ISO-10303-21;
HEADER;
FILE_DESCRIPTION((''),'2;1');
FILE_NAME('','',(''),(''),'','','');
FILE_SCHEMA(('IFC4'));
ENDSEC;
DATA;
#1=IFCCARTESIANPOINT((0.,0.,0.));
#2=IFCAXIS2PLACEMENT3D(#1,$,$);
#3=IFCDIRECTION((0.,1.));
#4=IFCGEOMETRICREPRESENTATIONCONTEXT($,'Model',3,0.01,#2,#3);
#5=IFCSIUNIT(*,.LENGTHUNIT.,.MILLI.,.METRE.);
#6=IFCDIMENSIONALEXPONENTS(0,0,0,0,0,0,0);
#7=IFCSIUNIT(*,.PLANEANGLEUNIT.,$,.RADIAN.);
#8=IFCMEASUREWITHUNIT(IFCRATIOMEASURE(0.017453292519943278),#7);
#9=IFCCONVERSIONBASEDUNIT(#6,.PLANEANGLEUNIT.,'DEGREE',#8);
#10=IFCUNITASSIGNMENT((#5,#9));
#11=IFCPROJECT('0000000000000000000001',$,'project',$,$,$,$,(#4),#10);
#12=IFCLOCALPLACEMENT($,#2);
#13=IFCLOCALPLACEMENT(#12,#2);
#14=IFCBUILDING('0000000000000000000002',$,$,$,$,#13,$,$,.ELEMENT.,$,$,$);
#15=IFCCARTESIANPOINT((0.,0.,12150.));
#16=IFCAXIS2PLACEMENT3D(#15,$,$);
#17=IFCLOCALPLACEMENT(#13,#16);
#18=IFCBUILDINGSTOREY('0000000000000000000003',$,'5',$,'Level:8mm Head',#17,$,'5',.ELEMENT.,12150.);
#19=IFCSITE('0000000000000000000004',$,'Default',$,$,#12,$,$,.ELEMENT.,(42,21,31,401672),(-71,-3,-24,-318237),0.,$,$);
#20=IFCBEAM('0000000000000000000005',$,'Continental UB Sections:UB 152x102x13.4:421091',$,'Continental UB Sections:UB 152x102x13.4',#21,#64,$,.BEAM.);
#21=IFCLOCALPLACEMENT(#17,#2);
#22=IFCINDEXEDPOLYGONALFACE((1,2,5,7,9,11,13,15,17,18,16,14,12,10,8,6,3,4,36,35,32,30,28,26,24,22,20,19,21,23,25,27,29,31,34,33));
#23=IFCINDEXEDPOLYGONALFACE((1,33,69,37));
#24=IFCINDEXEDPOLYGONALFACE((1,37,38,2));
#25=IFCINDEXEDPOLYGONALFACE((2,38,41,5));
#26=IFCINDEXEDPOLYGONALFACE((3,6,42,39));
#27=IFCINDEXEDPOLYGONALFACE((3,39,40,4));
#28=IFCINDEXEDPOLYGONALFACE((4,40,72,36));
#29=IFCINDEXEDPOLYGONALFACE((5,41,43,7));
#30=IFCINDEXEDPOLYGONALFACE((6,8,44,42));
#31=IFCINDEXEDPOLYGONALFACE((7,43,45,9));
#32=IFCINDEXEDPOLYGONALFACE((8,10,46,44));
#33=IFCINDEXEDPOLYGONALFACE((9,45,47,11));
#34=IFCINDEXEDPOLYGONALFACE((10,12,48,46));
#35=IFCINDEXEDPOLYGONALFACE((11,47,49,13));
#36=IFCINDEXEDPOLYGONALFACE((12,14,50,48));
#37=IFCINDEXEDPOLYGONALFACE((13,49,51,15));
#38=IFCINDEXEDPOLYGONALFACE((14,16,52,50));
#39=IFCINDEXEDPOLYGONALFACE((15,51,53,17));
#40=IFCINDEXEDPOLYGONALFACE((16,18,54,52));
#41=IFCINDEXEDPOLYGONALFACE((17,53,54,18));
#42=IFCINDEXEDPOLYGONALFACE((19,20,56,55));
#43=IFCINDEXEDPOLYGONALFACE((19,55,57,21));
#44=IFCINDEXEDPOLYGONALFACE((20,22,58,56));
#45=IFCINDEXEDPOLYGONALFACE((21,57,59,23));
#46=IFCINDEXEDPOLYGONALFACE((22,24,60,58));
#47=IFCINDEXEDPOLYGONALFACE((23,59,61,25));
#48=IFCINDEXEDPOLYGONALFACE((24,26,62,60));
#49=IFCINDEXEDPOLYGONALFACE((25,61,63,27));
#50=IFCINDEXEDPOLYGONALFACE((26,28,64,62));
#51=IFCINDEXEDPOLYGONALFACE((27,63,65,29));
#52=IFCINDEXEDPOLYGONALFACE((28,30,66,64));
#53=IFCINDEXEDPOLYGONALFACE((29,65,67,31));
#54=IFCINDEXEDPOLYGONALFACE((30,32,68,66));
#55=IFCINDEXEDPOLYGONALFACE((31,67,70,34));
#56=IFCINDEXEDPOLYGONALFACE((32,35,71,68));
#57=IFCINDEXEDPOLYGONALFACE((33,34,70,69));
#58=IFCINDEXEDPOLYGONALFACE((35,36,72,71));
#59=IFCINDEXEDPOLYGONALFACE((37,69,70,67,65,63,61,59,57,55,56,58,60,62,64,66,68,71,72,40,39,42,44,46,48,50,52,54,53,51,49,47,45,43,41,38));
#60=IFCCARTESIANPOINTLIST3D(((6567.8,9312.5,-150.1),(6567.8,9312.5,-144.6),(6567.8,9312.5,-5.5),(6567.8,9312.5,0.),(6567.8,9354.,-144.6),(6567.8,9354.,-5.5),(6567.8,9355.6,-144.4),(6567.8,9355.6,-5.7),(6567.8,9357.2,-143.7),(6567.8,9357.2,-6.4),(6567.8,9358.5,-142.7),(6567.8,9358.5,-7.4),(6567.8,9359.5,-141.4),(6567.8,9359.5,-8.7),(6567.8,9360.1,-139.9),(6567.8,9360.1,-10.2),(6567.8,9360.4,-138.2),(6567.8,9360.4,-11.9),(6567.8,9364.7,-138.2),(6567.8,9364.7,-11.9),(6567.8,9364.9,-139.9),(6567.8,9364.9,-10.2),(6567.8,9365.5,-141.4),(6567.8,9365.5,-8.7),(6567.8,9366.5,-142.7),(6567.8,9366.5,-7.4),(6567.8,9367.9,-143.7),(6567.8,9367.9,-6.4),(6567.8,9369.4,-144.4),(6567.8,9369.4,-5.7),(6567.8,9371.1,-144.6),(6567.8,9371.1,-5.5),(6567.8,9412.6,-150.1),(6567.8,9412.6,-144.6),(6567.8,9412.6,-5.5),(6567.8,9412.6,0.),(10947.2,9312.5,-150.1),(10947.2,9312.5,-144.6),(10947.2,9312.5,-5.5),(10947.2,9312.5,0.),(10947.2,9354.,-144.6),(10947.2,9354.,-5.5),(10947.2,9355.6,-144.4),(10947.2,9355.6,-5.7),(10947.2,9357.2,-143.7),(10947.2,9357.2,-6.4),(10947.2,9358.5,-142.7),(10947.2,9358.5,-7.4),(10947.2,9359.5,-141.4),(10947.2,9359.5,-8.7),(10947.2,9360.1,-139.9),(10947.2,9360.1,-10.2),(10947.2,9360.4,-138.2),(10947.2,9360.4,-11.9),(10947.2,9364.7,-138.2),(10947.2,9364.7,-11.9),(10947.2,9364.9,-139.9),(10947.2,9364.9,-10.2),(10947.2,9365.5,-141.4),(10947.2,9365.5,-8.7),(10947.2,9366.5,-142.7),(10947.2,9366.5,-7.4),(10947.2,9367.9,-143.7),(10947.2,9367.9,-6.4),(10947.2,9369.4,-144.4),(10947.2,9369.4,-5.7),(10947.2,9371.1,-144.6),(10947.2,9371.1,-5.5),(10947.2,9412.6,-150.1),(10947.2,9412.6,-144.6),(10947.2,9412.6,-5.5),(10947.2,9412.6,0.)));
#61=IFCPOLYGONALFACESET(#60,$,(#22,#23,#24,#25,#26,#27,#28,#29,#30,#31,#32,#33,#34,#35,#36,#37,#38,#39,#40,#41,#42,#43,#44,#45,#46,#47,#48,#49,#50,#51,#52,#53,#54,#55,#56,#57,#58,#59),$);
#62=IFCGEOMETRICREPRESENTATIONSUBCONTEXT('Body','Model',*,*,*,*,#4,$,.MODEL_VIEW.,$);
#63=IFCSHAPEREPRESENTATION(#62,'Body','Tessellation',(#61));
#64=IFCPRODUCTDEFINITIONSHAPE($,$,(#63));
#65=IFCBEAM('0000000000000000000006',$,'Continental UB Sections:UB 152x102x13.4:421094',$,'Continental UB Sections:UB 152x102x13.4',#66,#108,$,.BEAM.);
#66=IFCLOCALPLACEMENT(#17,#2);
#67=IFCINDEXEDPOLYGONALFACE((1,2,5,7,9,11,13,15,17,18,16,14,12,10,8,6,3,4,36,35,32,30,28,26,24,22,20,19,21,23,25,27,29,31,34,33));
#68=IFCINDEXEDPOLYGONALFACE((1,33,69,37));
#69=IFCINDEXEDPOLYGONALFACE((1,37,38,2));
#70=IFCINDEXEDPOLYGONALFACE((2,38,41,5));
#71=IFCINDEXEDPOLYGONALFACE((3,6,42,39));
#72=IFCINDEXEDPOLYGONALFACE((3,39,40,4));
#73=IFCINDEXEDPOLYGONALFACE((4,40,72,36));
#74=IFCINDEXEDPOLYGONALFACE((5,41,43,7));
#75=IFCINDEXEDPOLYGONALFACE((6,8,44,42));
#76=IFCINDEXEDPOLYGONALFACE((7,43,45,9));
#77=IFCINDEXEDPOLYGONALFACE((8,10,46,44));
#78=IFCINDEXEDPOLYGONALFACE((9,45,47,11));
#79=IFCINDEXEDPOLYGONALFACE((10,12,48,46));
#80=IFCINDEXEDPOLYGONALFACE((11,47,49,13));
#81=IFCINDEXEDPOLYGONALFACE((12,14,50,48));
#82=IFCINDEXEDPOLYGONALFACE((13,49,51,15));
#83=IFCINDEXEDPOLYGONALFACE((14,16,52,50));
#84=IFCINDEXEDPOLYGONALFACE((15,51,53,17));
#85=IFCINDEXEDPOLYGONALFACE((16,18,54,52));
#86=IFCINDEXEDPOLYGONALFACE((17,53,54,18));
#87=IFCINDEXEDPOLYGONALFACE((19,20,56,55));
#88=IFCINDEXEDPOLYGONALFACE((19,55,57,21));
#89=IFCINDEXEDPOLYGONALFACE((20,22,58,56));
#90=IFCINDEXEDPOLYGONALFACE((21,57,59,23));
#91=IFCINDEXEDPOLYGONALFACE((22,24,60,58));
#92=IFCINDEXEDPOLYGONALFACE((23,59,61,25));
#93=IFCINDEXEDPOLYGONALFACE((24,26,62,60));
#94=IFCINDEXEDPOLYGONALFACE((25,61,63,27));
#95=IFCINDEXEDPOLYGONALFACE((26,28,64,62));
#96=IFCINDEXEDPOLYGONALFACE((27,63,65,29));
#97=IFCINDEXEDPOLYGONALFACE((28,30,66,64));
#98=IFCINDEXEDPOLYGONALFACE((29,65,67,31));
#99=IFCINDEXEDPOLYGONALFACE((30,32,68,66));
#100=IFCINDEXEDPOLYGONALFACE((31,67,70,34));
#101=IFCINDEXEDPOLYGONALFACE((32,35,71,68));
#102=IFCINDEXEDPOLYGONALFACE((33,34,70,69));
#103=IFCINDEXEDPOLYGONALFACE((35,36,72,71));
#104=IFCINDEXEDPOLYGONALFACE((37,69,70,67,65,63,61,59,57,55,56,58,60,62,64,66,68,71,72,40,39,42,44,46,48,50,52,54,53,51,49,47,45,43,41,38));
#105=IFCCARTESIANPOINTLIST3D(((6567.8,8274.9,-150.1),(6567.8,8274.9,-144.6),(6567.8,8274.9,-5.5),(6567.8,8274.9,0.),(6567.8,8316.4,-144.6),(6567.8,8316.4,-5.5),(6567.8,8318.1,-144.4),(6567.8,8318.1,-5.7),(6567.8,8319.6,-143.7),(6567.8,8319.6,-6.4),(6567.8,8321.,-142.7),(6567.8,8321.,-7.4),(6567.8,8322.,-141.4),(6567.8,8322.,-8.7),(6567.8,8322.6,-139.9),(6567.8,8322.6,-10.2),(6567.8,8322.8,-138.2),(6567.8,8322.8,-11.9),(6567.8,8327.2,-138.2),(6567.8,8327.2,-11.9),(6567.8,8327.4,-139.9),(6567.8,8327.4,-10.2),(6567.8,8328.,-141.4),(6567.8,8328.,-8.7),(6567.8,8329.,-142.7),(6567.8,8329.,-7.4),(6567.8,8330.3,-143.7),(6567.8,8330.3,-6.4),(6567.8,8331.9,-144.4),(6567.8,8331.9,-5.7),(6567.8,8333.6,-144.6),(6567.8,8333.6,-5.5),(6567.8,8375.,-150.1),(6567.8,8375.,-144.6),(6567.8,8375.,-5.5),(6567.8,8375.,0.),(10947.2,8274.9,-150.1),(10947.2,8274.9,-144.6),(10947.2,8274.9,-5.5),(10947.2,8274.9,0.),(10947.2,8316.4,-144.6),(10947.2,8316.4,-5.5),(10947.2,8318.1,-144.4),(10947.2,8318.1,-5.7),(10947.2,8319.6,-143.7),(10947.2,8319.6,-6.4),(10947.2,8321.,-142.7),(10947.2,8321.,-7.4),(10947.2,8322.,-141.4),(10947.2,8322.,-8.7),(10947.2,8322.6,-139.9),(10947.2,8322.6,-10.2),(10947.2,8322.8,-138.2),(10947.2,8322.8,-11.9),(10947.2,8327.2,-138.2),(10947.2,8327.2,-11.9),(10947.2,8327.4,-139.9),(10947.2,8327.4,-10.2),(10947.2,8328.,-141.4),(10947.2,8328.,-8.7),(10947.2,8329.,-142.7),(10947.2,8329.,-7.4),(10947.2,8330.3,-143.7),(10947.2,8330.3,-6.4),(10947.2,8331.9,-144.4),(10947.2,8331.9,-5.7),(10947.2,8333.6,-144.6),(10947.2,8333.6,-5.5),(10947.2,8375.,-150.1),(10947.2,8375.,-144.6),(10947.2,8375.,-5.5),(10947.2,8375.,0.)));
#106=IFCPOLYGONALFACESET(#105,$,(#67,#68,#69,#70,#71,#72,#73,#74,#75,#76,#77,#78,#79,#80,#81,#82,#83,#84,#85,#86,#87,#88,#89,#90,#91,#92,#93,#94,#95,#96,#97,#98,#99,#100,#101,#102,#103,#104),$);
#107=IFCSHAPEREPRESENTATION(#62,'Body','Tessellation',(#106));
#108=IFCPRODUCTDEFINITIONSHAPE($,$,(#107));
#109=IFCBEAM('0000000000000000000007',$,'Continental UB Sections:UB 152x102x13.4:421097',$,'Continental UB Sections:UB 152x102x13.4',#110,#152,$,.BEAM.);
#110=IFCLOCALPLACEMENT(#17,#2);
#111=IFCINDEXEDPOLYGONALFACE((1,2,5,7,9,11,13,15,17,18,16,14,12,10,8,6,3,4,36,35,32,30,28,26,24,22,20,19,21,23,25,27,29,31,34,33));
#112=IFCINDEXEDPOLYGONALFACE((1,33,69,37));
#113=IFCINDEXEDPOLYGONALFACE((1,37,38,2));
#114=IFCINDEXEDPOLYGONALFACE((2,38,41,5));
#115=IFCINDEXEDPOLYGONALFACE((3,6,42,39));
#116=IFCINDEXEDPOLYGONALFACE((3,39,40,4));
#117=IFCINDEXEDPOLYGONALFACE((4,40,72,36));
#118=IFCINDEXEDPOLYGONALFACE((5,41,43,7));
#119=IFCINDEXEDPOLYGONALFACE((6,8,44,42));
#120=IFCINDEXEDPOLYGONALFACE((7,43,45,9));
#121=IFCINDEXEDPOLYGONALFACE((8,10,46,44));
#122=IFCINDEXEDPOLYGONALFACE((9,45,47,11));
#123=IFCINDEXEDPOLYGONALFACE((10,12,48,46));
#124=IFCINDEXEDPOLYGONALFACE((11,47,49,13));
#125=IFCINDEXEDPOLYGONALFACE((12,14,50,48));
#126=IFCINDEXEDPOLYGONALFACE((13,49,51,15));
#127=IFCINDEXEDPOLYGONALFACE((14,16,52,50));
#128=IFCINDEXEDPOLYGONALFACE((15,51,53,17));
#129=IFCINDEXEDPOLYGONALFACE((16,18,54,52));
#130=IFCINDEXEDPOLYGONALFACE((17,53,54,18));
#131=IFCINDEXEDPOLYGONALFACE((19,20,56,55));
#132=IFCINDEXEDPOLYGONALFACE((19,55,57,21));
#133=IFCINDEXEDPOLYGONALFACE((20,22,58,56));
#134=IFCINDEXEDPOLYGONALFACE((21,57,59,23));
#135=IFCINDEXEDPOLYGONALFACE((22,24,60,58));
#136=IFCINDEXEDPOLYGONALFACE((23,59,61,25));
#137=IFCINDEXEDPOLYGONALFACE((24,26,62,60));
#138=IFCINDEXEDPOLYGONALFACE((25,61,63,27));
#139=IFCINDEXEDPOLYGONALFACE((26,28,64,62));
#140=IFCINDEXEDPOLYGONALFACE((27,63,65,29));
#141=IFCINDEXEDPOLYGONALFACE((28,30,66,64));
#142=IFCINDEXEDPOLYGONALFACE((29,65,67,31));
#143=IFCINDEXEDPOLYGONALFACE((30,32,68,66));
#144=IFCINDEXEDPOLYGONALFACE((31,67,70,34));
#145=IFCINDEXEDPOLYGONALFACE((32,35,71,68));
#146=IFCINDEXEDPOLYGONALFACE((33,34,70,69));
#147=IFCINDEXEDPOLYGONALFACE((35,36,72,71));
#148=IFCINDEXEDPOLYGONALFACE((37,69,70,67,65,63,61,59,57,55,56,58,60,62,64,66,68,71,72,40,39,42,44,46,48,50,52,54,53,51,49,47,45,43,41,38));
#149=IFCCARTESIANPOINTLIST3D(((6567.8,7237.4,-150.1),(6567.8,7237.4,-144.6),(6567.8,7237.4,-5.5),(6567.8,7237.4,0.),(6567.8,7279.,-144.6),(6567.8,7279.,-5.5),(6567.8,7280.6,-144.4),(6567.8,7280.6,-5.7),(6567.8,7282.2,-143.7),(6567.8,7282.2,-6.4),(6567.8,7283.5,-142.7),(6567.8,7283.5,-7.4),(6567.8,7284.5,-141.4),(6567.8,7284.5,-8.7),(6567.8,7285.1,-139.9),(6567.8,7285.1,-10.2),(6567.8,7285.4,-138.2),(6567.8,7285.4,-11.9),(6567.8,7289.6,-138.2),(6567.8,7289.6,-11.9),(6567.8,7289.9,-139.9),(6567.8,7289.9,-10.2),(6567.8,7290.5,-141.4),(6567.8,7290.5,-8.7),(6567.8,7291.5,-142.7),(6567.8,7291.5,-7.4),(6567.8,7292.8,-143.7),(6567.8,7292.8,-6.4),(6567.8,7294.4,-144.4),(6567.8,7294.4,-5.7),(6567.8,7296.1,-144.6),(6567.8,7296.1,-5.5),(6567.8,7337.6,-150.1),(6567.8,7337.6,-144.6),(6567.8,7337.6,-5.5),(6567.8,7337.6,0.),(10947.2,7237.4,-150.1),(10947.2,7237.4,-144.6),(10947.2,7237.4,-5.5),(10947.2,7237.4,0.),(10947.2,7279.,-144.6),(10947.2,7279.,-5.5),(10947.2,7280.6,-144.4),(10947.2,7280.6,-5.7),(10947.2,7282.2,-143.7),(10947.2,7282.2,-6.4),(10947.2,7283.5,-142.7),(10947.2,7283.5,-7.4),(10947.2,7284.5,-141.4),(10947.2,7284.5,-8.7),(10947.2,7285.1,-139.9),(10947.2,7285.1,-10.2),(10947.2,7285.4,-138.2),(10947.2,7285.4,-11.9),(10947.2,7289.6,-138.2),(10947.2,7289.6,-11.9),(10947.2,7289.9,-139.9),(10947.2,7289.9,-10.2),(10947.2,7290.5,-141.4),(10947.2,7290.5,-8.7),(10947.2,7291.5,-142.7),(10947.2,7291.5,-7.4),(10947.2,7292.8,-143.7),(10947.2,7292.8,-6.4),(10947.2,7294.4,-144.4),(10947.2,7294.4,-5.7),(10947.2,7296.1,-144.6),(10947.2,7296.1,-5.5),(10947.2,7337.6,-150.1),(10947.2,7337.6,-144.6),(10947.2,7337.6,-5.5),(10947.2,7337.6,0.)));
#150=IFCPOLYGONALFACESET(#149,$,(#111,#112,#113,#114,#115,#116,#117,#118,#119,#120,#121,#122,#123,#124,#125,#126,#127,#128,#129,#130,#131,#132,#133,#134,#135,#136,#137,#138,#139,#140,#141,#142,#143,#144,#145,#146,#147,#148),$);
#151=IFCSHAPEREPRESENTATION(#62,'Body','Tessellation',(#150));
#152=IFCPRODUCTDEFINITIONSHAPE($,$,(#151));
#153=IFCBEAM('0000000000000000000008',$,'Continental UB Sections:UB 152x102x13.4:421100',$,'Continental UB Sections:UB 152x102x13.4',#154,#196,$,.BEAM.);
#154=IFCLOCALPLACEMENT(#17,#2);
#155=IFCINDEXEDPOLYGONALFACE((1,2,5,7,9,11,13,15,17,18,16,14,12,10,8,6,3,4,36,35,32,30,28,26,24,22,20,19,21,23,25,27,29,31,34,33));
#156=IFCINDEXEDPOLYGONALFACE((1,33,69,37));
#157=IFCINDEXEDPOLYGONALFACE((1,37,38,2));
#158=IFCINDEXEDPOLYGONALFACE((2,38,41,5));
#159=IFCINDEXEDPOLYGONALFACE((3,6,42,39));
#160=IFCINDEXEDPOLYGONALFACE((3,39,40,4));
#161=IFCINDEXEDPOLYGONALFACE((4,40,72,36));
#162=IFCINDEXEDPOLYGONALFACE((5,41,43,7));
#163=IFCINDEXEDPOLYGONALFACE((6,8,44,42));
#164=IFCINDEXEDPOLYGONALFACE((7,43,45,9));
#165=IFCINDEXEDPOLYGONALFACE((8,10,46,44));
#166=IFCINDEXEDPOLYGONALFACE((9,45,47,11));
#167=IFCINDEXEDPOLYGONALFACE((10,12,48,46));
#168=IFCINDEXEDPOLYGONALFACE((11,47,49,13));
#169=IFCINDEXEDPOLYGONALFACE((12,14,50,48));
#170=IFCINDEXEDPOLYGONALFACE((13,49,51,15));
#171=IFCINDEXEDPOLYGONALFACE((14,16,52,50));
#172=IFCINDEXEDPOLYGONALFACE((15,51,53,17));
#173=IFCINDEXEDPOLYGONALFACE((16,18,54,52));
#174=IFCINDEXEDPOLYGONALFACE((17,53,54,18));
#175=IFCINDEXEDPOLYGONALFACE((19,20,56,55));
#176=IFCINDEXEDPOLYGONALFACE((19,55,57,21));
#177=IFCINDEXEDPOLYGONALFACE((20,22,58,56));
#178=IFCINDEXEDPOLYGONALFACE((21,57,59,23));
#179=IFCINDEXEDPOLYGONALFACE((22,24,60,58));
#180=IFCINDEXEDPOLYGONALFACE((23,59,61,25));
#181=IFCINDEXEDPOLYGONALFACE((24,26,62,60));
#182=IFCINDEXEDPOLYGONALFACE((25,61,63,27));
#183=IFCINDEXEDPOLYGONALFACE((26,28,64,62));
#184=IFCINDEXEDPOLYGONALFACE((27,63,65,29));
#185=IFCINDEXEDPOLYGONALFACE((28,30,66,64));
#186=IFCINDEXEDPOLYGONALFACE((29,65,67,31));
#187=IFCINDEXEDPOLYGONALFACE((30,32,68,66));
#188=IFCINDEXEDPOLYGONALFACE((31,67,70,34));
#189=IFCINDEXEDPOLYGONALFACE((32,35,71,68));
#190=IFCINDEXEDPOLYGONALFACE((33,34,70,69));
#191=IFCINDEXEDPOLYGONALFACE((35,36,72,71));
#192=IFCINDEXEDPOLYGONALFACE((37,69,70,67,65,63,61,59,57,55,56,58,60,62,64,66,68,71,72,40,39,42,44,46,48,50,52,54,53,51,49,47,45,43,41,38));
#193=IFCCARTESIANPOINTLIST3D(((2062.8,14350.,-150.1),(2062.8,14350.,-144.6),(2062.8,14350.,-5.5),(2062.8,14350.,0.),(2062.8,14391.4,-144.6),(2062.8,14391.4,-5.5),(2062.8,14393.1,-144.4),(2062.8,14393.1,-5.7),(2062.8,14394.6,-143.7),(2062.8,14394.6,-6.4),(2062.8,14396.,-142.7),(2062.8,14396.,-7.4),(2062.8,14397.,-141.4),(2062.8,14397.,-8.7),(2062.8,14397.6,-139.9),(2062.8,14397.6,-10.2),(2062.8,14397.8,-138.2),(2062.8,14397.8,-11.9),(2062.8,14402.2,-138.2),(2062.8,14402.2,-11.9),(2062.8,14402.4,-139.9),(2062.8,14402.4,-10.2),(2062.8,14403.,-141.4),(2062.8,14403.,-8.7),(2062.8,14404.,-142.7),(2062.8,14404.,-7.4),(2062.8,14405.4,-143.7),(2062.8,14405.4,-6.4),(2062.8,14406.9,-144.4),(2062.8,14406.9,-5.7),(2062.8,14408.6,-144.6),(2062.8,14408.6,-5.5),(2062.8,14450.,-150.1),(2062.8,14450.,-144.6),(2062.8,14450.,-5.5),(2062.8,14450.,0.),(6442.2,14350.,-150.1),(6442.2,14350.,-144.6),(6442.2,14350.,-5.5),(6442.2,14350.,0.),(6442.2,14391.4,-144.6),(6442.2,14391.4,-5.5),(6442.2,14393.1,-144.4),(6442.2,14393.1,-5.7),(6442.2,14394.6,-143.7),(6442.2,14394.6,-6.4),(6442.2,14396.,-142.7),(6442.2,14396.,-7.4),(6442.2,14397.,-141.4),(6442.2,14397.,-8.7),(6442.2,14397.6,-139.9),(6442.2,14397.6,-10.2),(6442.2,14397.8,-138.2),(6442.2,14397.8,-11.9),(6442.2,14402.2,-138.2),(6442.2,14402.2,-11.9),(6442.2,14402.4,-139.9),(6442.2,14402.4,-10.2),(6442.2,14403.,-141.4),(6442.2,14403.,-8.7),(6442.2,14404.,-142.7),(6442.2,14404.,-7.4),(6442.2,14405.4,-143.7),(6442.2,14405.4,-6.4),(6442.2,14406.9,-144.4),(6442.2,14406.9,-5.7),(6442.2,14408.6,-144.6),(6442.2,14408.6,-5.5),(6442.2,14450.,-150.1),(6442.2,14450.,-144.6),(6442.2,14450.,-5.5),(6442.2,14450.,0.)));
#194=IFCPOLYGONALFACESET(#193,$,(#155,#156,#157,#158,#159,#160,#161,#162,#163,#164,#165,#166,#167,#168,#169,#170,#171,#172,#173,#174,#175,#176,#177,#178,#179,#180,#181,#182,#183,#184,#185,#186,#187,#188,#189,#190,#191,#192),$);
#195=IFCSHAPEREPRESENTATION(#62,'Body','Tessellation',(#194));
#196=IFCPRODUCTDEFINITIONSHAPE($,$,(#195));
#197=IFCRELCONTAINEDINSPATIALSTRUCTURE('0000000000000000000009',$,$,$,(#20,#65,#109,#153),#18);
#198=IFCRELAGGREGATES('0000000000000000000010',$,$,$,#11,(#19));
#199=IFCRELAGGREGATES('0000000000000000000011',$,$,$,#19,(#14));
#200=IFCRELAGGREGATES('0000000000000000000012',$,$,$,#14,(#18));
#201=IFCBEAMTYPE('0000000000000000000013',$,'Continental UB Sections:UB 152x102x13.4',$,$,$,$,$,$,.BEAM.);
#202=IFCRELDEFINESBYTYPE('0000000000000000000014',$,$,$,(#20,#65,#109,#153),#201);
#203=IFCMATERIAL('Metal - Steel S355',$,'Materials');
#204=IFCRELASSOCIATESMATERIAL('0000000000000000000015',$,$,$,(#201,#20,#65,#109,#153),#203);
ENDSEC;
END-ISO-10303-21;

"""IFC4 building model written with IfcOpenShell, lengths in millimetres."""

from ifc_helpers import new_model, entity, si_unit, converted_unit, direction, frame, origin, place, context, subcontext, project, spatial, line, arc, indexed_curve, outline, extrude, source, transform, mapped, material, type_object, type_shapes, element, save


model = new_model("IFC4")

# Units and contexts
model_context = context("Model", 3, precision=0.01, world=origin(), true_north=direction((0.0, 1.0)))
body_context = subcontext(model_context, "Body", "Model", "MODEL_VIEW")
ifc_project = project(units=[si_unit("LENGTHUNIT", "METRE", prefix="MILLI"), converted_unit("PLANEANGLEUNIT", "DEGREE", entity("IfcRatioMeasure", 0.017453292519943278), si_unit("PLANEANGLEUNIT", "RADIAN"), dimensions=[0, 0, 0, 0, 0, 0, 0])], contexts=[model_context])

# Site, building, storey
site_placement = place(None, origin())
site = spatial("IfcSite", under=ifc_project, at=site_placement, Name="Default", CompositionType="ELEMENT", RefLatitude=(42, 21, 31, 401672), RefLongitude=(-71, -3, -24, -318237), RefElevation=0.0)
building_placement = place(site_placement, origin())
building = spatial("IfcBuilding", under=site, at=building_placement, CompositionType="ELEMENT")
storey_placement = place(building_placement, frame((0.0, 0.0, 12150.0)))
storey = spatial("IfcBuildingStorey", under=building, at=storey_placement, Name="5", ObjectType="Level:8mm Head", LongName="5", CompositionType="ELEMENT", Elevation=12150.0)

# Beams
ifc_material = material(Name="Metal - Steel S355", Category="Materials")
beam_type_1 = type_object("IfcBeamType", Name="Continental UB Sections:UB 152x102x13.4", PredefinedType="BEAM", material=ifc_material)
shared_shape_1 = source(origin(), body_context, "Body", "SweptSolid", [
    extrude(outline(indexed_curve([(-75.0, -50.1), (-69.6, -50.1), (-69.6, -8.5), (-67.7, -4.0), (-63.2, -2.1), (63.1, -2.1), (67.7, -4.0), (69.5, -8.5), (69.5, -50.1), (75.1, -50.1), (75.1, 50.1), (69.5, 50.1), (69.5, 8.6), (67.7, 4.0), (63.1, 2.2), (-63.2, 2.2), (-67.7, 4.0), (-69.6, 8.6), (-69.6, 50.0), (-75.0, 50.0)], segments=[line(1, 2, 3), arc(3, 4, 5), line(5, 6), arc(6, 7, 8), line(8, 9, 10, 11, 12, 13), arc(13, 14, 15), line(15, 16), arc(16, 17, 18), line(18, 19, 20, 1)], self_intersect=False)), frame((-2189.7, 0.0, 0.0), z_axis=(1.0, 0.0, 0.0), x_axis=(0.0, 0.0, -1.0)), (0.0, 0.0, 1.0), 4379.4),
])
type_shapes(beam_type_1, [shared_shape_1])
for number, where, name in (
    (1, (8757.5, 9362.5, -75.1), "Continental UB Sections:UB 152x102x13.4:421091"),
    (2, (8757.5, 8325.0, -75.1), "Continental UB Sections:UB 152x102x13.4:421094"),
    (3, (8757.5, 7287.5, -75.1), "Continental UB Sections:UB 152x102x13.4:421097"),
    (4, (4252.5, 14400.0, -75.1), "Continental UB Sections:UB 152x102x13.4:421100"),
):
    element("IfcBeam", number, at=place(storey_placement, frame(where)), inside=storey, type_object=beam_type_1, material=ifc_material, Name=name, ObjectType="Continental UB Sections:UB 152x102x13.4", PredefinedType="BEAM", context=body_context, shape_type="MappedRepresentation", body=[
        mapped(shared_shape_1, transform((0.0, 0.0, 0.0), scale=1.0)),
    ])

save(model, "model.ifc")
